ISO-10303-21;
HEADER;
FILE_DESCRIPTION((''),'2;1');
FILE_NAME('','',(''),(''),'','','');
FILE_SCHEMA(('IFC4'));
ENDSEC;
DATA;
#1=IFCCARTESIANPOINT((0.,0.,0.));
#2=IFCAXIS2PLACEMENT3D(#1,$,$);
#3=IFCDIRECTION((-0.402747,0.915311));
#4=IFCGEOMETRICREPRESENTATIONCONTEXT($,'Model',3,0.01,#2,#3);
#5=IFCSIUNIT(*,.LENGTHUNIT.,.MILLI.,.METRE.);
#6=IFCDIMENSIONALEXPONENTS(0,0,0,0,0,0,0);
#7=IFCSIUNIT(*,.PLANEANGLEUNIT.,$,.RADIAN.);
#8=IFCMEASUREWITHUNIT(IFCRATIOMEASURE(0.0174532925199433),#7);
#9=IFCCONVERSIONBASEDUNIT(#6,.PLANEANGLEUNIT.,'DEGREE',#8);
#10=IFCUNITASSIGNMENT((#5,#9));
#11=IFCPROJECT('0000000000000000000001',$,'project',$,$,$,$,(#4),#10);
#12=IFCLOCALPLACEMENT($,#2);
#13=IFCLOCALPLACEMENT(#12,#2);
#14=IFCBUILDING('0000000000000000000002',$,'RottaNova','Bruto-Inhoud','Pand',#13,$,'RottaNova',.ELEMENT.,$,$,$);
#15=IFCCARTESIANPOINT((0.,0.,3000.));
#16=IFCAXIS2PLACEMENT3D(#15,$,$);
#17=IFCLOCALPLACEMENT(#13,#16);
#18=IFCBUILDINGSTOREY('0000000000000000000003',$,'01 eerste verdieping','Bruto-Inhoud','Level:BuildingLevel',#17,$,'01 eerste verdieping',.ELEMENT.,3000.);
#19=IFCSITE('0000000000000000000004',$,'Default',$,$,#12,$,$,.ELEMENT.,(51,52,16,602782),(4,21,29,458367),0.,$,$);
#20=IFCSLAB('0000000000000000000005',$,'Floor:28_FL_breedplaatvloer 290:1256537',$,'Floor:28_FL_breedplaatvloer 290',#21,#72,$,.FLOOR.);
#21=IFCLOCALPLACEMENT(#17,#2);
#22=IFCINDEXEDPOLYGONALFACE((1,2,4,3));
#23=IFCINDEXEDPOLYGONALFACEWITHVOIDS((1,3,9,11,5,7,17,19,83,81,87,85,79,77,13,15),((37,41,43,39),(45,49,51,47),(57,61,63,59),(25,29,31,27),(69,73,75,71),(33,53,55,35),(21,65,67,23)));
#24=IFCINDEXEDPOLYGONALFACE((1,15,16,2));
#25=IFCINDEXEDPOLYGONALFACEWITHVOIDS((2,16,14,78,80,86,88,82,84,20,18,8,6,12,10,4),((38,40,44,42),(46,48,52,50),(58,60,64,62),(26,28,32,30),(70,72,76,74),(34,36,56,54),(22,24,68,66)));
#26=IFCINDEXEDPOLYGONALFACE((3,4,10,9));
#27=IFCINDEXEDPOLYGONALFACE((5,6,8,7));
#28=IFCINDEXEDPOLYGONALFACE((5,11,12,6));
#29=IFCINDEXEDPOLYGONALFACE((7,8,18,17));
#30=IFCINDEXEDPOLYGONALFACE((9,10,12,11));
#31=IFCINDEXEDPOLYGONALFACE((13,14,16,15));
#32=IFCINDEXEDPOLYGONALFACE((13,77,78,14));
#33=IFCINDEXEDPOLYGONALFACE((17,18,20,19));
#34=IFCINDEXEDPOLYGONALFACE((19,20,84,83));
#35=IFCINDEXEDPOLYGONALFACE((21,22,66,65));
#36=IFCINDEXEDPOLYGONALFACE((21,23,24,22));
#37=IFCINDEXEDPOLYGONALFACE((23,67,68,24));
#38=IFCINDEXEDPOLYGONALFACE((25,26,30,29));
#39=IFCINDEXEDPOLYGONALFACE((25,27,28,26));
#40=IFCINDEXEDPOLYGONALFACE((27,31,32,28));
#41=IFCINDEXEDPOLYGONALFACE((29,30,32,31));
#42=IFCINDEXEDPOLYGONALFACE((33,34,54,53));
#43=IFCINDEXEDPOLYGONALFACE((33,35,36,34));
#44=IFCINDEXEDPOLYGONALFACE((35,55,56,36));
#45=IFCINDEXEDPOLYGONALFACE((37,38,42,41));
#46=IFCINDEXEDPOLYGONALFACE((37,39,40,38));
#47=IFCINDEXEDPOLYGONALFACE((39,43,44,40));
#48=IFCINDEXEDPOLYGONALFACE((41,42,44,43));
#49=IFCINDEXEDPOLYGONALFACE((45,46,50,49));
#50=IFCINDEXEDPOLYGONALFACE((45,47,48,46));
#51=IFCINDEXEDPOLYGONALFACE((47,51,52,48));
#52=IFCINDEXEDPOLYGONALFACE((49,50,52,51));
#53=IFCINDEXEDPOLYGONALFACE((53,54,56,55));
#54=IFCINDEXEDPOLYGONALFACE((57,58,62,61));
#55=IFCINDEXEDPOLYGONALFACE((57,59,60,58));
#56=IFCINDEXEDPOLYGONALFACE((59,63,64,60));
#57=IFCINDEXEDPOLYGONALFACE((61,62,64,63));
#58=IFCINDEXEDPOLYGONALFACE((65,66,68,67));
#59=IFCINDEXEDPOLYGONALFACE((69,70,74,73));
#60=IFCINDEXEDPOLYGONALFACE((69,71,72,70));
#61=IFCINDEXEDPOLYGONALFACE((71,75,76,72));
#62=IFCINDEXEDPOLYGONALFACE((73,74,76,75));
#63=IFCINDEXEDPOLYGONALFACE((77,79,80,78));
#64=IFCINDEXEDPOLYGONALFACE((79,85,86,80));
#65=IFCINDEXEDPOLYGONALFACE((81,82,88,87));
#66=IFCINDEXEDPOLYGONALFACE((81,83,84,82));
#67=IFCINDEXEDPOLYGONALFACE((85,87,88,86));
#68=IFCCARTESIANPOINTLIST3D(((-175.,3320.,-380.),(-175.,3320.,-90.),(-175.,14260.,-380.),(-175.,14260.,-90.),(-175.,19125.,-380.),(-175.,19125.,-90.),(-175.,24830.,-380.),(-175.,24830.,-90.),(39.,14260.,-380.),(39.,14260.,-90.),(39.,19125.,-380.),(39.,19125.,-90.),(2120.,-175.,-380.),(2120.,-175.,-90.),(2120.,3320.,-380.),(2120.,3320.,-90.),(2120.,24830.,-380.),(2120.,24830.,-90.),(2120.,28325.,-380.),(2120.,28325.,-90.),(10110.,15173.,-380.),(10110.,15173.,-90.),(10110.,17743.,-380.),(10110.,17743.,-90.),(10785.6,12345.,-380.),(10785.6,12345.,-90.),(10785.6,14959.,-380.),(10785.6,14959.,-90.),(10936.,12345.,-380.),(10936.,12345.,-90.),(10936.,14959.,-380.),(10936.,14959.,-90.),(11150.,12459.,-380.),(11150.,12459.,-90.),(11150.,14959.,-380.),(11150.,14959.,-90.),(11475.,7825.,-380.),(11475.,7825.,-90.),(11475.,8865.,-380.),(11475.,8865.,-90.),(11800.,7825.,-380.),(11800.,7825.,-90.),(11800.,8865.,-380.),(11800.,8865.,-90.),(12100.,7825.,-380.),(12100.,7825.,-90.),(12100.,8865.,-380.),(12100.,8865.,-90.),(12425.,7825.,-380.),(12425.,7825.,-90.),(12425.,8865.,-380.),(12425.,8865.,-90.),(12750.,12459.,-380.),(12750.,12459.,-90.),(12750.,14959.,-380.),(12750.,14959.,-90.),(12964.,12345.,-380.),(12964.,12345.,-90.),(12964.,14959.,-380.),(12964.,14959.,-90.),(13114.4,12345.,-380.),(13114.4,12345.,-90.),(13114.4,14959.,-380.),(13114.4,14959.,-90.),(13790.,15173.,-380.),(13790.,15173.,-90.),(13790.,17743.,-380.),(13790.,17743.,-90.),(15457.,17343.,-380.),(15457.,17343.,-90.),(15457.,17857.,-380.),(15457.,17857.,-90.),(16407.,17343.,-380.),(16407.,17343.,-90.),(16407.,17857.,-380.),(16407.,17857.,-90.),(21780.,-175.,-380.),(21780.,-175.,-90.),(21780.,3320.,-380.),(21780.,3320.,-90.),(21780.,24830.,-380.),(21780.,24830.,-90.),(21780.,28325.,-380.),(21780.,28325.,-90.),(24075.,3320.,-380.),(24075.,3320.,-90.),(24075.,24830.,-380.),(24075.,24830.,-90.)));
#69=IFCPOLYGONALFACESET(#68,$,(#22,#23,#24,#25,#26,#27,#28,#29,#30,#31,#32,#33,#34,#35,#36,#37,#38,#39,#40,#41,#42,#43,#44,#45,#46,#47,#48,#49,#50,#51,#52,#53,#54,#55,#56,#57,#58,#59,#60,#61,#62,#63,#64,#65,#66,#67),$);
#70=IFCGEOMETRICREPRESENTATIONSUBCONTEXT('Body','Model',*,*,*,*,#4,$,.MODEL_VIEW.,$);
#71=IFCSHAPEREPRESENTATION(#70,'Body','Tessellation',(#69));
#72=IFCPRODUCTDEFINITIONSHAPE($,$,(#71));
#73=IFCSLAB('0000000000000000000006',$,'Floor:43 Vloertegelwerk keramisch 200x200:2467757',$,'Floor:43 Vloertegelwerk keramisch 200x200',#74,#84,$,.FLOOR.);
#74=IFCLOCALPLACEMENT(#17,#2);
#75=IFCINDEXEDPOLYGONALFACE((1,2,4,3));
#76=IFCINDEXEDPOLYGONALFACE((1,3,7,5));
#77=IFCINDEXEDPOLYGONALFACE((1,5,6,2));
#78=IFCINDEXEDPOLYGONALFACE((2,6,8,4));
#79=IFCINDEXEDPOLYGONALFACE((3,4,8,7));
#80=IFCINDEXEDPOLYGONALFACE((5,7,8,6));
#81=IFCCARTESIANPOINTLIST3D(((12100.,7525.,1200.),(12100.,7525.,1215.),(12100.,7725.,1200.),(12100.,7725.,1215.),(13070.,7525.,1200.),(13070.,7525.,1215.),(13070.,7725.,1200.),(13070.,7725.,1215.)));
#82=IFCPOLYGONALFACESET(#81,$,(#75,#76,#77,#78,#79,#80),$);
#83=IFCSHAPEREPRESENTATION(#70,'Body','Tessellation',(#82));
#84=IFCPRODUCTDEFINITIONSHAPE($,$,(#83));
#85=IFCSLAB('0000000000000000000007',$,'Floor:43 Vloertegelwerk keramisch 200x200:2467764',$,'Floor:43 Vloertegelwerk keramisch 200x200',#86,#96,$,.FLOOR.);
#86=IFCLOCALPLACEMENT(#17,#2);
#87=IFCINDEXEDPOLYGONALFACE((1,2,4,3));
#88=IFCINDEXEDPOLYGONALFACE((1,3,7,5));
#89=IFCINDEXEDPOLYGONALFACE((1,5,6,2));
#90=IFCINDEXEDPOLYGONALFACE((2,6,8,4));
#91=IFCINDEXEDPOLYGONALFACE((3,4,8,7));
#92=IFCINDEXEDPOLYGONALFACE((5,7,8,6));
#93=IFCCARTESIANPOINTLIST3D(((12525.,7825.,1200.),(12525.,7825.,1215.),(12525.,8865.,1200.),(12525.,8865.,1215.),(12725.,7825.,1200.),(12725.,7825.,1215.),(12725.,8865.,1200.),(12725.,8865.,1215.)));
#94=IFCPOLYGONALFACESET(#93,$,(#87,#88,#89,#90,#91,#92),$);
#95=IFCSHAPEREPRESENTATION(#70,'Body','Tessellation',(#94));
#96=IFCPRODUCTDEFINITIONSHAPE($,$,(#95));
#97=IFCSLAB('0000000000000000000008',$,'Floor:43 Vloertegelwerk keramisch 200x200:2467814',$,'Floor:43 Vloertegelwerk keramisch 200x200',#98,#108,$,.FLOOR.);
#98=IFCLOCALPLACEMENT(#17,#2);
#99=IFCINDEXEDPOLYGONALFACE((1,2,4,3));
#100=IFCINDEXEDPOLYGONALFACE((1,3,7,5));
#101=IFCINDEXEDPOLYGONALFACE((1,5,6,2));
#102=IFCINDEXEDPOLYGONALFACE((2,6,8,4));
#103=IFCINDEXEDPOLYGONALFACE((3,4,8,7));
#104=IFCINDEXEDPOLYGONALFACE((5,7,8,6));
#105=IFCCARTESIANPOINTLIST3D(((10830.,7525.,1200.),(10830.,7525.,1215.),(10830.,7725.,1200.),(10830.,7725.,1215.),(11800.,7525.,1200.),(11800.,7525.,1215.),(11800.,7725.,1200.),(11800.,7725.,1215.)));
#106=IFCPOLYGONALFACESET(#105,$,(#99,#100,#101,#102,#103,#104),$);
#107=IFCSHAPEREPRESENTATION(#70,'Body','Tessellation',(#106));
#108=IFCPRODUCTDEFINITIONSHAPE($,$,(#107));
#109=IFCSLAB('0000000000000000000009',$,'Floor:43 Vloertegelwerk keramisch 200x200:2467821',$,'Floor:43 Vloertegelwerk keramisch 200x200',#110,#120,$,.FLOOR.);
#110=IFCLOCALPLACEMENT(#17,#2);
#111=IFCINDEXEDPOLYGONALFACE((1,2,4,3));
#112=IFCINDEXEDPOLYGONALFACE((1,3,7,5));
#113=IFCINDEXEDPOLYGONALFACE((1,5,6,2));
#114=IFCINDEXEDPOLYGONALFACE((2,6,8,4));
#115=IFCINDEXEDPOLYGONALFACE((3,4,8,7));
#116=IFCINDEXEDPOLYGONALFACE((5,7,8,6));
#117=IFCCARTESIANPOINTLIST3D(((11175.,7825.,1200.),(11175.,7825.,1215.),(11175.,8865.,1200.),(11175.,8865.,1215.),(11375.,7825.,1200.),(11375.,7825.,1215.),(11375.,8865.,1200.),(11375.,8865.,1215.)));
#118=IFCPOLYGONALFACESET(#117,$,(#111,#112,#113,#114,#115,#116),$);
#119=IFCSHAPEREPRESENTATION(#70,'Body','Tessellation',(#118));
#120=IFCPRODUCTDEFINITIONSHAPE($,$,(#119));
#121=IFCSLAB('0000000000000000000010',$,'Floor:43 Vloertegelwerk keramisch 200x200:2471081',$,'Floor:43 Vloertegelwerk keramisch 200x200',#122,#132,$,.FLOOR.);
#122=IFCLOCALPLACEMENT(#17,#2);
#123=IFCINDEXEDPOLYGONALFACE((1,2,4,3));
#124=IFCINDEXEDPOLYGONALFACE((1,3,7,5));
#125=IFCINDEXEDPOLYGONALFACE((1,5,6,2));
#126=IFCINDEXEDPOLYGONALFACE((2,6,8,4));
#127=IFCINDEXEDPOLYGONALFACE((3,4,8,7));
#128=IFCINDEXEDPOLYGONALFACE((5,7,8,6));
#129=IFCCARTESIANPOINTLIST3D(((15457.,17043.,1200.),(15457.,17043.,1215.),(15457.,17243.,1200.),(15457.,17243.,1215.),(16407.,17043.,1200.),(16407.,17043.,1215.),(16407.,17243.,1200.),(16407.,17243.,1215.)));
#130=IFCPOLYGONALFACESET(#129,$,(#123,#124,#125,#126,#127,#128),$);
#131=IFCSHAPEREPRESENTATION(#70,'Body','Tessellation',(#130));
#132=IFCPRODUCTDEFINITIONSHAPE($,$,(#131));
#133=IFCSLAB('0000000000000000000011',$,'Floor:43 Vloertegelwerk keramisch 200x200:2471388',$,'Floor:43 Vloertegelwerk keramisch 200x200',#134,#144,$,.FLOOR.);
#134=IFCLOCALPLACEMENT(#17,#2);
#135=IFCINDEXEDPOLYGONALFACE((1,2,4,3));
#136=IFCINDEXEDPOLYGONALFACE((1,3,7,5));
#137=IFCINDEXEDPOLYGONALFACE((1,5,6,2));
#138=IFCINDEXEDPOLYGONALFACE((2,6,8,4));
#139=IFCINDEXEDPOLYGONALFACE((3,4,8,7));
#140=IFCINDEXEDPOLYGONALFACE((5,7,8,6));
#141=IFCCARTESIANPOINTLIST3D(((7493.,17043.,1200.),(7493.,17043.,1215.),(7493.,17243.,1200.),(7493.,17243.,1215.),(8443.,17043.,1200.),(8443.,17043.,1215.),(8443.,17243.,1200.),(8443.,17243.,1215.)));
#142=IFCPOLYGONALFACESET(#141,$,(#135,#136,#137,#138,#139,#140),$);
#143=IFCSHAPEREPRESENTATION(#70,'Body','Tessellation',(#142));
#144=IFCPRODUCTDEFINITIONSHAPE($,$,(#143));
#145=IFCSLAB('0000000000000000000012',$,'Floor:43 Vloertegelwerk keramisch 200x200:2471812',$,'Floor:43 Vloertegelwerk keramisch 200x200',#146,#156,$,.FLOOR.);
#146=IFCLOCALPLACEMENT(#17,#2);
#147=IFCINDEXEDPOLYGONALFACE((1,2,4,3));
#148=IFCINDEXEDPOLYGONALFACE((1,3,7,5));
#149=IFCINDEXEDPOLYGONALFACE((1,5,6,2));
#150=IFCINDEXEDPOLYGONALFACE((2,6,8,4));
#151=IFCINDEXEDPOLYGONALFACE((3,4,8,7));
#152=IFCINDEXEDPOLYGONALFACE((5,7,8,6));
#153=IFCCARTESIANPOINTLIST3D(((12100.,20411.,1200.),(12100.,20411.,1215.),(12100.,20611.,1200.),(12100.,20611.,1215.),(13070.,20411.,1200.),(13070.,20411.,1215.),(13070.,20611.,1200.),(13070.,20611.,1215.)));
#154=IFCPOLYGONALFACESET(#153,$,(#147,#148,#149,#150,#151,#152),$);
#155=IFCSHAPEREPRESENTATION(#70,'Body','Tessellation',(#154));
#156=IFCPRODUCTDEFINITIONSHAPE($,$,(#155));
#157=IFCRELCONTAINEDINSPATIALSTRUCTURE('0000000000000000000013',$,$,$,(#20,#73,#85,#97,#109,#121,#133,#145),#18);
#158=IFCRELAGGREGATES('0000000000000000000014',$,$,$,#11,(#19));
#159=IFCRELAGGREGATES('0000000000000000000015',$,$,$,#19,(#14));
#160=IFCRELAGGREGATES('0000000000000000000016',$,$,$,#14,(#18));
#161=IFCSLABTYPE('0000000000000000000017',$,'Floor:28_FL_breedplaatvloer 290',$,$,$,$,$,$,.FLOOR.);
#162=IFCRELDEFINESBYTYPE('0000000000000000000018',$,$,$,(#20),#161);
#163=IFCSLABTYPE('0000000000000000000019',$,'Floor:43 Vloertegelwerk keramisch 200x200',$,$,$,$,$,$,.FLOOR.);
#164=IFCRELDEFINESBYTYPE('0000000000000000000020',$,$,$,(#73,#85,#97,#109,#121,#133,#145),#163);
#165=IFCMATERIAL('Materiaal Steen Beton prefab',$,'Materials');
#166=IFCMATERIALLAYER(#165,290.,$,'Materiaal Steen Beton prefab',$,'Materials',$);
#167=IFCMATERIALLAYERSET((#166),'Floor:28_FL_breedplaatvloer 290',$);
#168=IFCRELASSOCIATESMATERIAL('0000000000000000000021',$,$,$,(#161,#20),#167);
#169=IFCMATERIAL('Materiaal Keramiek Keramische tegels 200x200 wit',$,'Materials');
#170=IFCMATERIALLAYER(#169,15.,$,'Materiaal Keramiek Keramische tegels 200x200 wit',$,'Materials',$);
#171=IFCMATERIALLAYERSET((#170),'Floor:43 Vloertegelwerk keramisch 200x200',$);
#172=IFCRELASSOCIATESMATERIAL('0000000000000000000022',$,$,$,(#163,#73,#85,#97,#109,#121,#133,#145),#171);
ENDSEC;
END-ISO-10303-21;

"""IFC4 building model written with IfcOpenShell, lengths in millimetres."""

from ifc_helpers import new_model, entity, si_unit, converted_unit, direction, frame, frame_2d, origin, origin_2d_with_axis, place, context, subcontext, project, spatial, polyline, rectangle, outline, extrude, material, layer, layer_set, layer_usage, type_object, element, save


model = new_model("IFC4")

# Units and contexts
model_context = context("Model", 3, precision=0.01, world=origin(), true_north=direction((-0.402747, 0.915311)))
body_context = subcontext(model_context, "Body", "Model", "MODEL_VIEW")
ifc_project = project(units=[si_unit("LENGTHUNIT", "METRE", prefix="MILLI"), converted_unit("PLANEANGLEUNIT", "DEGREE", entity("IfcRatioMeasure", 0.0174532925199433), si_unit("PLANEANGLEUNIT", "RADIAN"), dimensions=[0, 0, 0, 0, 0, 0, 0])], contexts=[model_context])

# Site, building, storey
site_placement = place(None, origin())
site = spatial("IfcSite", under=ifc_project, at=site_placement, Name="Default", CompositionType="ELEMENT", RefLatitude=(51, 52, 16, 602782), RefLongitude=(4, 21, 29, 458367), RefElevation=0.0)
building_placement = place(site_placement, origin())
building = spatial("IfcBuilding", under=site, at=building_placement, Name="RottaNova", Description="Bruto-Inhoud", ObjectType="Pand", LongName="RottaNova", CompositionType="ELEMENT")
storey_placement = place(building_placement, frame((0.0, 0.0, 3000.0)))
storey = spatial("IfcBuildingStorey", under=building, at=storey_placement, Name="01 eerste verdieping", Description="Bruto-Inhoud", ObjectType="Level:BuildingLevel", LongName="01 eerste verdieping", CompositionType="ELEMENT", Elevation=3000.0)

# Slab, openings
ifc_material_1 = material(Name="Materiaal Steen Beton prefab", Category="Materials")
ifc_layer_1 = layer(ifc_material_1, 290.0, Name="Materiaal Steen Beton prefab", Category="Materials")
ifc_layer_set_1 = layer_set([ifc_layer_1], Name="Floor:28_FL_breedplaatvloer 290")
ifc_layer_usage_1 = layer_usage(ifc_layer_set_1, "AXIS3", "POSITIVE", 0.0)
slab_type_1 = type_object("IfcSlabType", Name="Floor:28_FL_breedplaatvloer 290", PredefinedType="FLOOR", material=ifc_layer_set_1)
slab_1_placement = place(storey_placement, frame((-175.0, -175.0, -380.0)))
slab_1 = element("IfcSlab", 1, at=slab_1_placement, inside=storey, type_object=slab_type_1, material=ifc_layer_usage_1, Name="Floor:28_FL_breedplaatvloer 290:1256537", ObjectType="Floor:28_FL_breedplaatvloer 290", PredefinedType="FLOOR", context=body_context, shape_type="SweptSolid", body=[
    extrude(outline(polyline([(-9830.0, 14250.0), (-9830.0, 10755.0), (-12125.0, 10755.0), (-12125.0, -10755.0), (-9830.0, -10755.0), (-9830.0, -14250.0), (3525.0, -14250.0), (9830.0, -14250.0), (9830.0, -10755.0), (12125.0, -10755.0), (12125.0, 185.0), (11911.0, 185.0), (11911.0, 5050.0), (12125.0, 5050.0), (12125.0, 10755.0), (9830.0, 10755.0), (9830.0, 14250.0), (-9830.0, 14250.0)])), frame((12125.0, 14250.0, 290.0), z_axis=(0.0, 0.0, -1.0), x_axis=(-1.0, 0.0, 0.0)), (0.0, 0.0, 1.0), 290.0),
])
opening_1_placement = place(storey_placement, frame((-175.0, -175.0, -380.0)))
element("IfcOpeningElement", 2, at=opening_1_placement, cuts=slab_1, ObjectType="Opening", context=body_context, shape_type="SweptSolid", body=[
    extrude(rectangle(XDim=1040.0, YDim=325.0, at=frame_2d((-312.5, -5730.0), x_axis=(0.0, -1.0))), frame((12125.0, 14250.0, 290.0), z_axis=(0.0, 0.0, -1.0), x_axis=(-1.0, 0.0, 0.0)), (0.0, 0.0, 1.0), 290.0),
])
opening_2_placement = place(storey_placement, frame((-175.0, -175.0, -380.0)))
element("IfcOpeningElement", 3, at=opening_2_placement, cuts=slab_1, ObjectType="Opening", context=body_context, shape_type="SweptSolid", body=[
    extrude(rectangle(XDim=514.0, YDim=950.0, at=frame_2d((-3982.0, 3525.0), x_axis=(0.0, -1.0))), frame((12125.0, 14250.0, 290.0), z_axis=(0.0, 0.0, -1.0), x_axis=(-1.0, 0.0, 0.0)), (0.0, 0.0, 1.0), 290.0),
])
opening_3_placement = place(storey_placement, frame((-175.0, -175.0, -380.0)))
element("IfcOpeningElement", 4, at=opening_3_placement, cuts=slab_1, ObjectType="Opening", context=body_context, shape_type="SweptSolid", body=[
    extrude(rectangle(XDim=1040.0, YDim=325.0, at=frame_2d((312.5, -5730.0), x_axis=(0.0, -1.0))), frame((12125.0, 14250.0, 290.0), z_axis=(0.0, 0.0, -1.0), x_axis=(-1.0, 0.0, 0.0)), (0.0, 0.0, 1.0), 290.0),
])
opening_4_placement = place(storey_placement, frame((-175.0, -175.0, -380.0)))
element("IfcOpeningElement", 5, at=opening_4_placement, cuts=slab_1, ObjectType="Opening", context=body_context, shape_type="SweptSolid", body=[
    extrude(rectangle(XDim=150.4, YDim=2614.0, at=frame_2d((1089.2, -423.0), x_axis=(1.0, 0.0))), frame((12125.0, 14250.0, 290.0), z_axis=(0.0, 0.0, -1.0), x_axis=(-1.0, 0.0, 0.0)), (0.0, 0.0, 1.0), 290.0),
])
opening_5_placement = place(storey_placement, frame((-175.0, -175.0, -380.0)))
element("IfcOpeningElement", 6, at=opening_5_placement, cuts=slab_1, ObjectType="Opening", context=body_context, shape_type="SweptSolid", body=[
    extrude(rectangle(XDim=150.4, YDim=2614.0, at=frame_2d((-1089.2, -423.0), x_axis=(-1.0, 0.0))), frame((12125.0, 14250.0, 290.0), z_axis=(0.0, 0.0, -1.0), x_axis=(-1.0, 0.0, 0.0)), (0.0, 0.0, 1.0), 290.0),
])
opening_6_placement = place(slab_1_placement, frame((12125.0, 13884.0, 290.0)))
element("IfcOpeningElement", 7, at=opening_6_placement, cuts=slab_1, ObjectType="Opening", context=body_context, shape_type="SweptSolid", body=[
    extrude(rectangle(XDim=2500.0, YDim=1600.0, at=origin_2d_with_axis()), frame((0.0, 0.0, 0.0), z_axis=(0.0, 0.0, -1.0), x_axis=(0.0, -1.0, 0.0)), (0.0, 0.0, 1.0), 290.0),
])
opening_7_placement = place(slab_1_placement, frame((12125.0, 16633.0, 290.0)))
element("IfcOpeningElement", 8, at=opening_7_placement, cuts=slab_1, ObjectType="Opening", context=body_context, shape_type="SweptSolid", body=[
    extrude(rectangle(XDim=2570.0, YDim=3680.0, at=origin_2d_with_axis()), frame((0.0, 0.0, 0.0), z_axis=(0.0, 0.0, -1.0), x_axis=(0.0, 1.0, 0.0)), (0.0, 0.0, 1.0), 290.0),
])

# Slabs
ifc_material_2 = material(Name="Materiaal Keramiek Keramische tegels 200x200 wit", Category="Materials")
ifc_layer_2 = layer(ifc_material_2, 15.0, Name="Materiaal Keramiek Keramische tegels 200x200 wit", Category="Materials")
ifc_layer_set_2 = layer_set([ifc_layer_2], Name="Floor:43 Vloertegelwerk keramisch 200x200")
ifc_layer_usage_2 = layer_usage(ifc_layer_set_2, "AXIS3", "POSITIVE", 0.0)
slab_type_2 = type_object("IfcSlabType", Name="Floor:43 Vloertegelwerk keramisch 200x200", PredefinedType="FLOOR", material=ifc_layer_set_2)
slab_2_placement = place(storey_placement, origin())
element("IfcSlab", 9, at=slab_2_placement, inside=storey, type_object=slab_type_2, material=ifc_layer_usage_2, Name="Floor:43 Vloertegelwerk keramisch 200x200:2467757", ObjectType="Floor:43 Vloertegelwerk keramisch 200x200", PredefinedType="FLOOR", context=body_context, shape_type="SweptSolid", body=[
    extrude(rectangle(XDim=200.0, YDim=970.0, at=origin_2d_with_axis()), frame((12585.0, 7625.0, 1215.0), z_axis=(0.0, 0.0, -1.0), x_axis=(0.0, 1.0, 0.0)), (0.0, 0.0, 1.0), 15.0),
])
slab_3_placement = place(storey_placement, origin())
element("IfcSlab", 10, at=slab_3_placement, inside=storey, type_object=slab_type_2, material=ifc_layer_usage_2, Name="Floor:43 Vloertegelwerk keramisch 200x200:2467764", ObjectType="Floor:43 Vloertegelwerk keramisch 200x200", PredefinedType="FLOOR", context=body_context, shape_type="SweptSolid", body=[
    extrude(rectangle(XDim=1040.0, YDim=200.0, at=origin_2d_with_axis()), frame((12625.0, 8345.0, 1215.0), z_axis=(0.0, 0.0, -1.0), x_axis=(0.0, 1.0, 0.0)), (0.0, 0.0, 1.0), 15.0),
])
slab_4_placement = place(storey_placement, origin())
element("IfcSlab", 11, at=slab_4_placement, inside=storey, type_object=slab_type_2, material=ifc_layer_usage_2, Name="Floor:43 Vloertegelwerk keramisch 200x200:2467814", ObjectType="Floor:43 Vloertegelwerk keramisch 200x200", PredefinedType="FLOOR", context=body_context, shape_type="SweptSolid", body=[
    extrude(rectangle(XDim=200.0, YDim=970.0, at=origin_2d_with_axis()), frame((11315.0, 7625.0, 1215.0), z_axis=(0.0, 0.0, -1.0), x_axis=(0.0, 1.0, 0.0)), (0.0, 0.0, 1.0), 15.0),
])
slab_5_placement = place(storey_placement, origin())
element("IfcSlab", 12, at=slab_5_placement, inside=storey, type_object=slab_type_2, material=ifc_layer_usage_2, Name="Floor:43 Vloertegelwerk keramisch 200x200:2467821", ObjectType="Floor:43 Vloertegelwerk keramisch 200x200", PredefinedType="FLOOR", context=body_context, shape_type="SweptSolid", body=[
    extrude(rectangle(XDim=1040.0, YDim=200.0, at=origin_2d_with_axis()), frame((11275.0, 8345.0, 1215.0), z_axis=(0.0, 0.0, -1.0), x_axis=(0.0, 1.0, 0.0)), (0.0, 0.0, 1.0), 15.0),
])
slab_6_placement = place(storey_placement, origin())
element("IfcSlab", 13, at=slab_6_placement, inside=storey, type_object=slab_type_2, material=ifc_layer_usage_2, Name="Floor:43 Vloertegelwerk keramisch 200x200:2471081", ObjectType="Floor:43 Vloertegelwerk keramisch 200x200", PredefinedType="FLOOR", context=body_context, shape_type="SweptSolid", body=[
    extrude(rectangle(XDim=200.0, YDim=950.0, at=frame_2d((0.0, 0.0), x_axis=(1.0, 0.0))), frame((15932.0, 17143.0, 1215.0), z_axis=(0.0, 0.0, -1.0), x_axis=(0.0, 1.0, 0.0)), (0.0, 0.0, 1.0), 15.0),
])
slab_7_placement = place(storey_placement, origin())
element("IfcSlab", 14, at=slab_7_placement, inside=storey, type_object=slab_type_2, material=ifc_layer_usage_2, Name="Floor:43 Vloertegelwerk keramisch 200x200:2471388", ObjectType="Floor:43 Vloertegelwerk keramisch 200x200", PredefinedType="FLOOR", context=body_context, shape_type="SweptSolid", body=[
    extrude(rectangle(XDim=200.0, YDim=950.0, at=frame_2d((0.0, 0.0), x_axis=(1.0, 0.0))), frame((7968.0, 17143.0, 1215.0), z_axis=(0.0, 0.0, -1.0), x_axis=(0.0, 1.0, 0.0)), (0.0, 0.0, 1.0), 15.0),
])
slab_8_placement = place(storey_placement, origin())
element("IfcSlab", 15, at=slab_8_placement, inside=storey, type_object=slab_type_2, material=ifc_layer_usage_2, Name="Floor:43 Vloertegelwerk keramisch 200x200:2471812", ObjectType="Floor:43 Vloertegelwerk keramisch 200x200", PredefinedType="FLOOR", context=body_context, shape_type="SweptSolid", body=[
    extrude(rectangle(XDim=200.0, YDim=970.0, at=origin_2d_with_axis()), frame((12585.0, 20511.0, 1215.0), z_axis=(0.0, 0.0, -1.0), x_axis=(0.0, 1.0, 0.0)), (0.0, 0.0, 1.0), 15.0),
])

save(model, "model.ifc")
